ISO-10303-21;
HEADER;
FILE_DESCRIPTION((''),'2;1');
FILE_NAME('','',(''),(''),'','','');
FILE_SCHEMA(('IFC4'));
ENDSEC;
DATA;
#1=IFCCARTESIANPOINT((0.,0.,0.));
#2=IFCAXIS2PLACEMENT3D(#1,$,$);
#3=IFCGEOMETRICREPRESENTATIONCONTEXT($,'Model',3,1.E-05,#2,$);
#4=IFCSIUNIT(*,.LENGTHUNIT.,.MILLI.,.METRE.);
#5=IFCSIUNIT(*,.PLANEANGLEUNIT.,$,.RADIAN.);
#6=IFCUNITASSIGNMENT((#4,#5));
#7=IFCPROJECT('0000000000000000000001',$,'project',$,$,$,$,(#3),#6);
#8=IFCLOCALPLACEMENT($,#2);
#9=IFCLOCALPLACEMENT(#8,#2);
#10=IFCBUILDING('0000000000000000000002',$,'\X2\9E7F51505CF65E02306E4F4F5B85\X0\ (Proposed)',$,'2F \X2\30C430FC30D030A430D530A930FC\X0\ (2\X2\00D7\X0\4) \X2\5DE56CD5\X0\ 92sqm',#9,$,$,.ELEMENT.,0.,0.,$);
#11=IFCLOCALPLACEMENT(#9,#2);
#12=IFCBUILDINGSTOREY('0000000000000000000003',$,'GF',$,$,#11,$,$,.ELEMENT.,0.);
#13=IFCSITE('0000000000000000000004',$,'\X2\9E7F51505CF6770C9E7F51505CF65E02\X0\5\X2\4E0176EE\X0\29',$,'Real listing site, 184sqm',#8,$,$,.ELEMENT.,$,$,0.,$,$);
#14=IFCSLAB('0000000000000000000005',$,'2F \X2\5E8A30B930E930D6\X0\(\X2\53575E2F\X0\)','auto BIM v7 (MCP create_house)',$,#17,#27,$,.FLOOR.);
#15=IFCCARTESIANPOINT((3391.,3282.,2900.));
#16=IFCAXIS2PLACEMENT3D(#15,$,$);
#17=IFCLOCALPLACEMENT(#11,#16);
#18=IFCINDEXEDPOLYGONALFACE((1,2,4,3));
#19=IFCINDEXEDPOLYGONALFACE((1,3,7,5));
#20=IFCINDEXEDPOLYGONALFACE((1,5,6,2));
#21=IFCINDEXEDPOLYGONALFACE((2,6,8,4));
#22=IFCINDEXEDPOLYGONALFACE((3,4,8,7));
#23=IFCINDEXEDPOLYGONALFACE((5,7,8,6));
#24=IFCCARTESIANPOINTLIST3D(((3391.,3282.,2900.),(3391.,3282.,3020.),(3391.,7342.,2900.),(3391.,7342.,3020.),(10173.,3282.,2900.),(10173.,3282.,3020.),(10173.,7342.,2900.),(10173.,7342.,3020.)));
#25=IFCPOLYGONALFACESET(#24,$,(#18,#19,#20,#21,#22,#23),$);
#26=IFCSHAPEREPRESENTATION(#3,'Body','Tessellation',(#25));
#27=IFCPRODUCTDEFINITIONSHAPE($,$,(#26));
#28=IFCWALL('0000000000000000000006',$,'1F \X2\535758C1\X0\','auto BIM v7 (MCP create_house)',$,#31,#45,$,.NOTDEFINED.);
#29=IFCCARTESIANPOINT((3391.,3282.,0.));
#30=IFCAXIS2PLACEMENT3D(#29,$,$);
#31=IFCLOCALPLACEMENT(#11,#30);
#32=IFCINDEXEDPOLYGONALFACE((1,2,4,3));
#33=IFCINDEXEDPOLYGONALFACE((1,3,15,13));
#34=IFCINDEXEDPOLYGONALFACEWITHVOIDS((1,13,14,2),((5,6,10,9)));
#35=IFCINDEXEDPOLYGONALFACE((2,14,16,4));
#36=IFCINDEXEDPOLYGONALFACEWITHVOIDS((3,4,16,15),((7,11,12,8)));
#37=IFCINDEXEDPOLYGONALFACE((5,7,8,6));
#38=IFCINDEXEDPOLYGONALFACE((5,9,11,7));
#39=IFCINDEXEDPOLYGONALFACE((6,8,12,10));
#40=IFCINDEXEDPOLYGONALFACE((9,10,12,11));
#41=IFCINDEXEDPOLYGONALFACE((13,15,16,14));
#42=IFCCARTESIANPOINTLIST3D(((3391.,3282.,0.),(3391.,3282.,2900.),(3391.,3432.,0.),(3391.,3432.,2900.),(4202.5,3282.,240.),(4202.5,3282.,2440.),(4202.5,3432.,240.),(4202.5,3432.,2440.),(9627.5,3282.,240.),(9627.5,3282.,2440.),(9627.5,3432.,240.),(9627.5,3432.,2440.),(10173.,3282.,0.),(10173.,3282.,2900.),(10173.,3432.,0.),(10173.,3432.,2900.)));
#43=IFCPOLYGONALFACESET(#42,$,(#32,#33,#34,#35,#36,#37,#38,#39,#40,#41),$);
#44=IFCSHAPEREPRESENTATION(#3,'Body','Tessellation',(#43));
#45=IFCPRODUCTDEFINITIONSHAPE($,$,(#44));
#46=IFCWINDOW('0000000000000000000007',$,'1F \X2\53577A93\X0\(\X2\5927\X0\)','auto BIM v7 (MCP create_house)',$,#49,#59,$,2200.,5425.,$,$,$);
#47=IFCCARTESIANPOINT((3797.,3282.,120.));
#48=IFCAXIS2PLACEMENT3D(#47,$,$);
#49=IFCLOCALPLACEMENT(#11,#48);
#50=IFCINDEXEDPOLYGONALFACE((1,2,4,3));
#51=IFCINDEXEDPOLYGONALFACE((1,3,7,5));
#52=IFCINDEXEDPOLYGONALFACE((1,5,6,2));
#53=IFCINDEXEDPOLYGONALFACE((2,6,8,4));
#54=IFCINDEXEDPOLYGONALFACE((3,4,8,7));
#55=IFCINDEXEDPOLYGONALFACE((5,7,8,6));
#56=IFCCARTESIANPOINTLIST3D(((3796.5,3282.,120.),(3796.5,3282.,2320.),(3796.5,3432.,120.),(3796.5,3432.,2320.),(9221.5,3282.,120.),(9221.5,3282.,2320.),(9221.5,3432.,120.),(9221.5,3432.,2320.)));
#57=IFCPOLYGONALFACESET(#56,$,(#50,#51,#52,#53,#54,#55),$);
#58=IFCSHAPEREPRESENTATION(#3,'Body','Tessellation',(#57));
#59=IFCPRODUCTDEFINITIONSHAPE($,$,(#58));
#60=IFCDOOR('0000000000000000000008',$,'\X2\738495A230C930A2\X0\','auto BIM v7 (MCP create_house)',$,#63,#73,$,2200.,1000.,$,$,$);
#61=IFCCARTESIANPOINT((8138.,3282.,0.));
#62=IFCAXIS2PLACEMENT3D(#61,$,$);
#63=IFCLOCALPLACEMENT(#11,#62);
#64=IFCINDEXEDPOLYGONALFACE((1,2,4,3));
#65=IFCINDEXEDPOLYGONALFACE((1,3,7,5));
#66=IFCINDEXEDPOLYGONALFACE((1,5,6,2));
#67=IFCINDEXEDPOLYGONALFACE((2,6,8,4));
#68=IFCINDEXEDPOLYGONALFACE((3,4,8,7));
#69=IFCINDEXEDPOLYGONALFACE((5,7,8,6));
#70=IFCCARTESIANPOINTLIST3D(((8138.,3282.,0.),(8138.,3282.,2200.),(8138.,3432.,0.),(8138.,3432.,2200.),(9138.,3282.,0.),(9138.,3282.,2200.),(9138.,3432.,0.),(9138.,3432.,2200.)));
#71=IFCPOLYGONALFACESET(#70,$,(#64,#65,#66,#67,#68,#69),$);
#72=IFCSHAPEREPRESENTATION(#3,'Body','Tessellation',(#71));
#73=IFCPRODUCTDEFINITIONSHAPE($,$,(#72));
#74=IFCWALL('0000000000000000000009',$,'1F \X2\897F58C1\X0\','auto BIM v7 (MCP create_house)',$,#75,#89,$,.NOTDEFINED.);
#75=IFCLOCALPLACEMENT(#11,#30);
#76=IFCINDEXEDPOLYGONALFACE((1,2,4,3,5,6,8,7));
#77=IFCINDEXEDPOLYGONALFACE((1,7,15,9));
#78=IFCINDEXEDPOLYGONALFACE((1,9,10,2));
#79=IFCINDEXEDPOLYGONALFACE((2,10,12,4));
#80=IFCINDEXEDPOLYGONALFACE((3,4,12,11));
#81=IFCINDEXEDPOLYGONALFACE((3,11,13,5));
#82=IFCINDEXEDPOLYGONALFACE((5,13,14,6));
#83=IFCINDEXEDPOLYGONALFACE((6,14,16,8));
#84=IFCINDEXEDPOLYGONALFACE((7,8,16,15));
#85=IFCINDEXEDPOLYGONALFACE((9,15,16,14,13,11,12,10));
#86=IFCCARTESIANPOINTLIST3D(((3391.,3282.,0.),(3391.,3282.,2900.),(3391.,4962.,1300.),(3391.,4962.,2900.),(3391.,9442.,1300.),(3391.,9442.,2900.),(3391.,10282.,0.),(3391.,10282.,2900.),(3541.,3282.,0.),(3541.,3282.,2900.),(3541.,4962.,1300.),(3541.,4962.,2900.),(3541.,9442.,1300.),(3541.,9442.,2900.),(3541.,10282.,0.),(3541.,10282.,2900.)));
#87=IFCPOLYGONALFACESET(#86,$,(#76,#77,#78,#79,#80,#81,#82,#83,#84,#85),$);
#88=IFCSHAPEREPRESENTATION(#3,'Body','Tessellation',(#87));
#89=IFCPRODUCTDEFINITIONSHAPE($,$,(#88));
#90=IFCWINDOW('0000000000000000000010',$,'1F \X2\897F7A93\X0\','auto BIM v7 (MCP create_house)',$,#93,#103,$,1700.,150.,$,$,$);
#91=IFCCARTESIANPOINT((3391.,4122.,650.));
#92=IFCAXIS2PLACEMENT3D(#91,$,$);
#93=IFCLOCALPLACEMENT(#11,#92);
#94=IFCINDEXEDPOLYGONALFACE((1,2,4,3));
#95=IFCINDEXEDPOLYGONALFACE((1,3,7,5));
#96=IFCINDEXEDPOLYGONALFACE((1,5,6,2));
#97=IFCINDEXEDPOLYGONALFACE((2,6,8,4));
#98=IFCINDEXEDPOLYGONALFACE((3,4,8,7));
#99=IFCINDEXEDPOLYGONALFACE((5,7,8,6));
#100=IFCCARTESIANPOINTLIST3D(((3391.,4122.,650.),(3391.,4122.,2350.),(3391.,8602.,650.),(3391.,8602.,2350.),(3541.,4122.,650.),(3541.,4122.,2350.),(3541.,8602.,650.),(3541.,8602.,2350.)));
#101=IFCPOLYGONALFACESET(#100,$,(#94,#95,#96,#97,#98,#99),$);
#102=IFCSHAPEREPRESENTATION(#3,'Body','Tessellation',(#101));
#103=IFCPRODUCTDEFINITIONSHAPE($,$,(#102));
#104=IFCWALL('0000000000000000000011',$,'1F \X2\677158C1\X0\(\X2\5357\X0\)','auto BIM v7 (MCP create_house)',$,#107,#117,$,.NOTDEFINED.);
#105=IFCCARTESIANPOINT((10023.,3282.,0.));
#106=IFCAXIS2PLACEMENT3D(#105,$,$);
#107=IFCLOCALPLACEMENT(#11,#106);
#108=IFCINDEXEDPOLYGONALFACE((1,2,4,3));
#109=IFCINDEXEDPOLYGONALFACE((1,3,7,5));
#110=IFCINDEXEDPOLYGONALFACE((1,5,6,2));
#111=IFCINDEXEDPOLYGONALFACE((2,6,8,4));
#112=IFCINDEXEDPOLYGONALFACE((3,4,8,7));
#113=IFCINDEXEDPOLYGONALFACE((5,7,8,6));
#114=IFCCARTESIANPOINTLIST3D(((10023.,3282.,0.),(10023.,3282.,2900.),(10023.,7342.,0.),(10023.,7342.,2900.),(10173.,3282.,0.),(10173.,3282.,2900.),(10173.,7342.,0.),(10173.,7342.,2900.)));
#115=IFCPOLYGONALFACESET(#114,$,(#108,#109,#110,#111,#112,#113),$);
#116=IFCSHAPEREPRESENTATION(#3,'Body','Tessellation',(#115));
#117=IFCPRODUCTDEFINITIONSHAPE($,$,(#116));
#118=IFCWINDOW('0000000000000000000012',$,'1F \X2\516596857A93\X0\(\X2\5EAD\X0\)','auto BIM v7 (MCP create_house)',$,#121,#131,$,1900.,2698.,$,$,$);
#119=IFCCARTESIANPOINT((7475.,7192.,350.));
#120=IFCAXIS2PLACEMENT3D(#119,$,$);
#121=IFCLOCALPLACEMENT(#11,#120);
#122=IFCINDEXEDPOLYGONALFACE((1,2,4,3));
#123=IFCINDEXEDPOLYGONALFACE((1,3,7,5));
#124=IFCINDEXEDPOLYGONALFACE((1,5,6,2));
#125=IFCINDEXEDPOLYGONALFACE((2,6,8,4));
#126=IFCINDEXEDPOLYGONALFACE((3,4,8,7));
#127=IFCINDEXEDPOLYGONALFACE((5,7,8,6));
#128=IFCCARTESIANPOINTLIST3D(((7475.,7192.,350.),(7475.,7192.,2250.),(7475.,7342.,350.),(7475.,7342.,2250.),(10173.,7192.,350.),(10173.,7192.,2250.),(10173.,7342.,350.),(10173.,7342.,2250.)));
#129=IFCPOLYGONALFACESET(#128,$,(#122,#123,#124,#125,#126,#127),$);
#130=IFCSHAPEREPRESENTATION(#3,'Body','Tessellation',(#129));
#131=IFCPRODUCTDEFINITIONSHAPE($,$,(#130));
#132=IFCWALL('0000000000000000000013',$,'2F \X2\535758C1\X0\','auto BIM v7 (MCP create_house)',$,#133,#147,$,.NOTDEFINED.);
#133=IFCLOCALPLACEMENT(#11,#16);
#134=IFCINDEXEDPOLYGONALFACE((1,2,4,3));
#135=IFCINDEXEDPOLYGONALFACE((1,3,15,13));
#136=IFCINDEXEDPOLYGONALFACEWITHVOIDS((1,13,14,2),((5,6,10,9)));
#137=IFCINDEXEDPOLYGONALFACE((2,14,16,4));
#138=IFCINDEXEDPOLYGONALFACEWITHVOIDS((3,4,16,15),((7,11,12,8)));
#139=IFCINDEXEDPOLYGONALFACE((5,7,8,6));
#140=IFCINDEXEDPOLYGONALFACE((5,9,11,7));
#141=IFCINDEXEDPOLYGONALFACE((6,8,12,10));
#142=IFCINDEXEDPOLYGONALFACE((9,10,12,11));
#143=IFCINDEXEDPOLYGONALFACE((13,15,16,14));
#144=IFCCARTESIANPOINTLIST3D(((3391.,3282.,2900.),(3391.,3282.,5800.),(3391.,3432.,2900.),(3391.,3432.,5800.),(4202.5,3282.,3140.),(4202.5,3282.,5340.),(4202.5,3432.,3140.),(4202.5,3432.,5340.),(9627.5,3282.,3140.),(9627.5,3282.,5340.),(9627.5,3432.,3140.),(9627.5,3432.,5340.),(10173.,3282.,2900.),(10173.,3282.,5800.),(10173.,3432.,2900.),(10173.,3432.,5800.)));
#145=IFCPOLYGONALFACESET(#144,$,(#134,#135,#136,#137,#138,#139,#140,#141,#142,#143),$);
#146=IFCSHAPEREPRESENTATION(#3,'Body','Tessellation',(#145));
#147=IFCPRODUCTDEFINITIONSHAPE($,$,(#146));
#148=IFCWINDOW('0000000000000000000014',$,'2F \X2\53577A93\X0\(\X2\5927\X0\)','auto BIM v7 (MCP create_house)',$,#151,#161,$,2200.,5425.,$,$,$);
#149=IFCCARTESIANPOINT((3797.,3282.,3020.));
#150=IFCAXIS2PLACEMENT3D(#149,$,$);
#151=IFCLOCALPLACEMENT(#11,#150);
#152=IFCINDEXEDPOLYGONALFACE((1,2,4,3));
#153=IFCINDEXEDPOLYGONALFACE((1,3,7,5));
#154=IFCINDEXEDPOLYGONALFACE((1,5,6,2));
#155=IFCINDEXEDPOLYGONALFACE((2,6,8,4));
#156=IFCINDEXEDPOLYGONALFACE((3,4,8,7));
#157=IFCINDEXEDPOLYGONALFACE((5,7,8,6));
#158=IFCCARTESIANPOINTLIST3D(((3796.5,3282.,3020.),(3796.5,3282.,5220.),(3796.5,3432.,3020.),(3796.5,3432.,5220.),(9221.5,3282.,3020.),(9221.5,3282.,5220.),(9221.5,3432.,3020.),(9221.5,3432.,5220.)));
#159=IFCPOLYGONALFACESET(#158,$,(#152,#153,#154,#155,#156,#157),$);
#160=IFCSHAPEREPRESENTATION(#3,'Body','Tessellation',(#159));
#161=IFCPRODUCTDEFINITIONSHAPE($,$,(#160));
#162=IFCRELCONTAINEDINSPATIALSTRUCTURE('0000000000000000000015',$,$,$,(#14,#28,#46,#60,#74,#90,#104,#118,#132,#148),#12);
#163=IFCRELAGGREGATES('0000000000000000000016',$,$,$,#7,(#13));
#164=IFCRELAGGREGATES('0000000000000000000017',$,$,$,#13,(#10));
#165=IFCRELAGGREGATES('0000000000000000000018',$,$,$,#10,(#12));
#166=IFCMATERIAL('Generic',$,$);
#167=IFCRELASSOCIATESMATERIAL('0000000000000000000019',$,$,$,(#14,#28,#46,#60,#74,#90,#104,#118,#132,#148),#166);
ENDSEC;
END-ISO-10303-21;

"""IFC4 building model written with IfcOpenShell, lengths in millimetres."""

from ifc_helpers import new_model, si_unit, frame, frame_2d, origin, place, context, project, spatial, rectangle, extrude, material, element, fill, save


model = new_model("IFC4")

# Units and contexts
model_context = context("Model", 3, precision=1e-05, world=origin())
ifc_project = project(units=[si_unit("LENGTHUNIT", "METRE", prefix="MILLI"), si_unit("PLANEANGLEUNIT", "RADIAN")], contexts=[model_context])

# Site, building, storey
site_placement = place(None, origin())
site = spatial("IfcSite", under=ifc_project, at=site_placement, Name="鹿児島県鹿児島市5丁目29", ObjectType="Real listing site, 184sqm", CompositionType="ELEMENT", RefElevation=0.0)
building_placement = place(site_placement, origin())
building = spatial("IfcBuilding", under=site, at=building_placement, Name="鹿児島市の住宅 (Proposed)", ObjectType="2F ツーバイフォー (2×4) 工法 92sqm", CompositionType="ELEMENT", ElevationOfRefHeight=0.0, ElevationOfTerrain=0.0)
storey_placement = place(building_placement, origin())
storey = spatial("IfcBuildingStorey", under=building, at=storey_placement, Name="GF", CompositionType="ELEMENT", Elevation=0.0)

# Slab
ifc_material = material(Name="Generic")
slab_1_placement = place(storey_placement, frame((3391.0, 3282.0, 2900.0)))
element("IfcSlab", 1, at=slab_1_placement, inside=storey, material=ifc_material, Name="2F 床スラブ(南帯)", Description="auto BIM v7 (MCP create_house)", PredefinedType="FLOOR", context=model_context, shape_type="SweptSolid", body=[
    extrude(rectangle(XDim=6782.0, YDim=4060.0, at=frame_2d((3391.0, 2030.0))), frame((3391.0, 3282.0, 2900.0)), (0.0, 0.0, 1.0), 120.0),
])

# Wall, openings, window, door
wall_1_placement = place(storey_placement, frame((3391.0, 3282.0, 0.0)))
wall_1 = element("IfcWall", 2, at=wall_1_placement, inside=storey, material=ifc_material, Name="1F 南壁", Description="auto BIM v7 (MCP create_house)", PredefinedType="NOTDEFINED", context=model_context, shape_type="SweptSolid", body=[
    extrude(rectangle(XDim=6782.0, YDim=150.0, at=frame_2d((3391.0, 75.0))), frame((3391.0, 3282.0, 0.0)), (0.0, 0.0, 1.0), 2900.0),
])
opening_1_placement = place(storey_placement, frame((3797.0, 3282.0, 120.0)))
opening_1 = element("IfcOpeningElement", 3, at=opening_1_placement, cuts=wall_1, PredefinedType="NOTDEFINED", context=model_context, shape_type="SweptSolid", body=[
    extrude(rectangle(XDim=5425.0, YDim=150.0, at=frame_2d((2712.0, 75.0))), frame((3797.0, 3282.0, 120.0)), (0.0, 0.0, 1.0), 2200.0),
])
opening_2_placement = place(storey_placement, frame((8138.0, 3282.0, 0.0)))
opening_2 = element("IfcOpeningElement", 4, at=opening_2_placement, cuts=wall_1, PredefinedType="NOTDEFINED", context=model_context, shape_type="SweptSolid", body=[
    extrude(rectangle(XDim=1000.0, YDim=150.0, at=frame_2d((500.0, 75.0))), frame((8138.0, 3282.0, 0.0)), (0.0, 0.0, 1.0), 2200.0),
])
window_1_placement = place(storey_placement, frame((3797.0, 3282.0, 120.0)))
window_1 = element("IfcWindow", 5, at=window_1_placement, inside=storey, material=ifc_material, Name="1F 南窓(大)", Description="auto BIM v7 (MCP create_house)", OverallHeight=2200.0, OverallWidth=5425.0, context=model_context, shape_type="SweptSolid", body=[
    extrude(rectangle(XDim=5425.0, YDim=150.0, at=frame_2d((2712.0, 75.0))), frame((3797.0, 3282.0, 120.0)), (0.0, 0.0, 1.0), 2200.0),
])
fill(opening_1, window_1)
door_placement = place(storey_placement, frame((8138.0, 3282.0, 0.0)))
door = element("IfcDoor", 6, at=door_placement, inside=storey, material=ifc_material, Name="玄関ドア", Description="auto BIM v7 (MCP create_house)", OverallHeight=2200.0, OverallWidth=1000.0, context=model_context, shape_type="SweptSolid", body=[
    extrude(rectangle(XDim=1000.0, YDim=150.0, at=frame_2d((500.0, 75.0))), frame((8138.0, 3282.0, 0.0)), (0.0, 0.0, 1.0), 2200.0),
])
fill(opening_2, door)

# Walls, openings, windows
wall_2_placement = place(storey_placement, frame((3391.0, 3282.0, 0.0)))
wall_2 = element("IfcWall", 7, at=wall_2_placement, inside=storey, material=ifc_material, Name="1F 西壁", Description="auto BIM v7 (MCP create_house)", PredefinedType="NOTDEFINED", context=model_context, shape_type="SweptSolid", body=[
    extrude(rectangle(XDim=150.0, YDim=7000.0, at=frame_2d((75.0, 3500.0))), frame((3391.0, 3282.0, 0.0)), (0.0, 0.0, 1.0), 2900.0),
])
opening_3_placement = place(storey_placement, frame((3391.0, 4122.0, 650.0)))
opening_3 = element("IfcOpeningElement", 8, at=opening_3_placement, cuts=wall_2, PredefinedType="NOTDEFINED", context=model_context, shape_type="SweptSolid", body=[
    extrude(rectangle(XDim=150.0, YDim=4480.0, at=frame_2d((75.0, 2240.0))), frame((3391.0, 4122.0, 650.0)), (0.0, 0.0, 1.0), 1700.0),
])
window_2_placement = place(storey_placement, frame((3391.0, 4122.0, 650.0)))
window_2 = element("IfcWindow", 9, at=window_2_placement, inside=storey, material=ifc_material, Name="1F 西窓", Description="auto BIM v7 (MCP create_house)", OverallHeight=1700.0, OverallWidth=150.0, context=model_context, shape_type="SweptSolid", body=[
    extrude(rectangle(XDim=150.0, YDim=4480.0, at=frame_2d((75.0, 2240.0))), frame((3391.0, 4122.0, 650.0)), (0.0, 0.0, 1.0), 1700.0),
])
fill(opening_3, window_2)
wall_3_placement = place(storey_placement, frame((10023.0, 3282.0, 0.0)))
wall_3 = element("IfcWall", 10, at=wall_3_placement, inside=storey, material=ifc_material, Name="1F 東壁(南)", Description="auto BIM v7 (MCP create_house)", PredefinedType="NOTDEFINED", context=model_context, shape_type="SweptSolid", body=[
    extrude(rectangle(XDim=150.0, YDim=4060.0, at=frame_2d((75.0, 2030.0))), frame((10023.0, 3282.0, 0.0)), (0.0, 0.0, 1.0), 2900.0),
])
opening_4_placement = place(storey_placement, frame((7475.0, 7192.0, 350.0)))
opening_4 = element("IfcOpeningElement", 11, at=opening_4_placement, cuts=wall_3, PredefinedType="NOTDEFINED", context=model_context, shape_type="SweptSolid", body=[
    extrude(rectangle(XDim=2698.0, YDim=150.0, at=frame_2d((1349.0, 75.0))), frame((7475.0, 7192.0, 350.0)), (0.0, 0.0, 1.0), 1900.0),
])
window_3_placement = place(storey_placement, frame((7475.0, 7192.0, 350.0)))
window_3 = element("IfcWindow", 12, at=window_3_placement, inside=storey, material=ifc_material, Name="1F 入隅窓(庭)", Description="auto BIM v7 (MCP create_house)", OverallHeight=1900.0, OverallWidth=2698.0, context=model_context, shape_type="SweptSolid", body=[
    extrude(rectangle(XDim=2698.0, YDim=150.0, at=frame_2d((1349.0, 75.0))), frame((7475.0, 7192.0, 350.0)), (0.0, 0.0, 1.0), 1900.0),
])
fill(opening_4, window_3)

# Wall, opening, window
wall_4_placement = place(storey_placement, frame((3391.0, 3282.0, 2900.0)))
wall_4 = element("IfcWall", 13, at=wall_4_placement, inside=storey, material=ifc_material, Name="2F 南壁", Description="auto BIM v7 (MCP create_house)", PredefinedType="NOTDEFINED", context=model_context, shape_type="SweptSolid", body=[
    extrude(rectangle(XDim=6782.0, YDim=150.0, at=frame_2d((3391.0, 75.0))), frame((3391.0, 3282.0, 2900.0)), (0.0, 0.0, 1.0), 2900.0),
])
opening_5_placement = place(storey_placement, frame((3797.0, 3282.0, 3020.0)))
opening_5 = element("IfcOpeningElement", 14, at=opening_5_placement, cuts=wall_4, PredefinedType="NOTDEFINED", context=model_context, shape_type="SweptSolid", body=[
    extrude(rectangle(XDim=5425.0, YDim=150.0, at=frame_2d((2712.0, 75.0))), frame((3797.0, 3282.0, 3020.0)), (0.0, 0.0, 1.0), 2200.0),
])
window_4_placement = place(storey_placement, frame((3797.0, 3282.0, 3020.0)))
window_4 = element("IfcWindow", 15, at=window_4_placement, inside=storey, material=ifc_material, Name="2F 南窓(大)", Description="auto BIM v7 (MCP create_house)", OverallHeight=2200.0, OverallWidth=5425.0, context=model_context, shape_type="SweptSolid", body=[
    extrude(rectangle(XDim=5425.0, YDim=150.0, at=frame_2d((2712.0, 75.0))), frame((3797.0, 3282.0, 3020.0)), (0.0, 0.0, 1.0), 2200.0),
])
fill(opening_5, window_4)

save(model, "model.ifc")
